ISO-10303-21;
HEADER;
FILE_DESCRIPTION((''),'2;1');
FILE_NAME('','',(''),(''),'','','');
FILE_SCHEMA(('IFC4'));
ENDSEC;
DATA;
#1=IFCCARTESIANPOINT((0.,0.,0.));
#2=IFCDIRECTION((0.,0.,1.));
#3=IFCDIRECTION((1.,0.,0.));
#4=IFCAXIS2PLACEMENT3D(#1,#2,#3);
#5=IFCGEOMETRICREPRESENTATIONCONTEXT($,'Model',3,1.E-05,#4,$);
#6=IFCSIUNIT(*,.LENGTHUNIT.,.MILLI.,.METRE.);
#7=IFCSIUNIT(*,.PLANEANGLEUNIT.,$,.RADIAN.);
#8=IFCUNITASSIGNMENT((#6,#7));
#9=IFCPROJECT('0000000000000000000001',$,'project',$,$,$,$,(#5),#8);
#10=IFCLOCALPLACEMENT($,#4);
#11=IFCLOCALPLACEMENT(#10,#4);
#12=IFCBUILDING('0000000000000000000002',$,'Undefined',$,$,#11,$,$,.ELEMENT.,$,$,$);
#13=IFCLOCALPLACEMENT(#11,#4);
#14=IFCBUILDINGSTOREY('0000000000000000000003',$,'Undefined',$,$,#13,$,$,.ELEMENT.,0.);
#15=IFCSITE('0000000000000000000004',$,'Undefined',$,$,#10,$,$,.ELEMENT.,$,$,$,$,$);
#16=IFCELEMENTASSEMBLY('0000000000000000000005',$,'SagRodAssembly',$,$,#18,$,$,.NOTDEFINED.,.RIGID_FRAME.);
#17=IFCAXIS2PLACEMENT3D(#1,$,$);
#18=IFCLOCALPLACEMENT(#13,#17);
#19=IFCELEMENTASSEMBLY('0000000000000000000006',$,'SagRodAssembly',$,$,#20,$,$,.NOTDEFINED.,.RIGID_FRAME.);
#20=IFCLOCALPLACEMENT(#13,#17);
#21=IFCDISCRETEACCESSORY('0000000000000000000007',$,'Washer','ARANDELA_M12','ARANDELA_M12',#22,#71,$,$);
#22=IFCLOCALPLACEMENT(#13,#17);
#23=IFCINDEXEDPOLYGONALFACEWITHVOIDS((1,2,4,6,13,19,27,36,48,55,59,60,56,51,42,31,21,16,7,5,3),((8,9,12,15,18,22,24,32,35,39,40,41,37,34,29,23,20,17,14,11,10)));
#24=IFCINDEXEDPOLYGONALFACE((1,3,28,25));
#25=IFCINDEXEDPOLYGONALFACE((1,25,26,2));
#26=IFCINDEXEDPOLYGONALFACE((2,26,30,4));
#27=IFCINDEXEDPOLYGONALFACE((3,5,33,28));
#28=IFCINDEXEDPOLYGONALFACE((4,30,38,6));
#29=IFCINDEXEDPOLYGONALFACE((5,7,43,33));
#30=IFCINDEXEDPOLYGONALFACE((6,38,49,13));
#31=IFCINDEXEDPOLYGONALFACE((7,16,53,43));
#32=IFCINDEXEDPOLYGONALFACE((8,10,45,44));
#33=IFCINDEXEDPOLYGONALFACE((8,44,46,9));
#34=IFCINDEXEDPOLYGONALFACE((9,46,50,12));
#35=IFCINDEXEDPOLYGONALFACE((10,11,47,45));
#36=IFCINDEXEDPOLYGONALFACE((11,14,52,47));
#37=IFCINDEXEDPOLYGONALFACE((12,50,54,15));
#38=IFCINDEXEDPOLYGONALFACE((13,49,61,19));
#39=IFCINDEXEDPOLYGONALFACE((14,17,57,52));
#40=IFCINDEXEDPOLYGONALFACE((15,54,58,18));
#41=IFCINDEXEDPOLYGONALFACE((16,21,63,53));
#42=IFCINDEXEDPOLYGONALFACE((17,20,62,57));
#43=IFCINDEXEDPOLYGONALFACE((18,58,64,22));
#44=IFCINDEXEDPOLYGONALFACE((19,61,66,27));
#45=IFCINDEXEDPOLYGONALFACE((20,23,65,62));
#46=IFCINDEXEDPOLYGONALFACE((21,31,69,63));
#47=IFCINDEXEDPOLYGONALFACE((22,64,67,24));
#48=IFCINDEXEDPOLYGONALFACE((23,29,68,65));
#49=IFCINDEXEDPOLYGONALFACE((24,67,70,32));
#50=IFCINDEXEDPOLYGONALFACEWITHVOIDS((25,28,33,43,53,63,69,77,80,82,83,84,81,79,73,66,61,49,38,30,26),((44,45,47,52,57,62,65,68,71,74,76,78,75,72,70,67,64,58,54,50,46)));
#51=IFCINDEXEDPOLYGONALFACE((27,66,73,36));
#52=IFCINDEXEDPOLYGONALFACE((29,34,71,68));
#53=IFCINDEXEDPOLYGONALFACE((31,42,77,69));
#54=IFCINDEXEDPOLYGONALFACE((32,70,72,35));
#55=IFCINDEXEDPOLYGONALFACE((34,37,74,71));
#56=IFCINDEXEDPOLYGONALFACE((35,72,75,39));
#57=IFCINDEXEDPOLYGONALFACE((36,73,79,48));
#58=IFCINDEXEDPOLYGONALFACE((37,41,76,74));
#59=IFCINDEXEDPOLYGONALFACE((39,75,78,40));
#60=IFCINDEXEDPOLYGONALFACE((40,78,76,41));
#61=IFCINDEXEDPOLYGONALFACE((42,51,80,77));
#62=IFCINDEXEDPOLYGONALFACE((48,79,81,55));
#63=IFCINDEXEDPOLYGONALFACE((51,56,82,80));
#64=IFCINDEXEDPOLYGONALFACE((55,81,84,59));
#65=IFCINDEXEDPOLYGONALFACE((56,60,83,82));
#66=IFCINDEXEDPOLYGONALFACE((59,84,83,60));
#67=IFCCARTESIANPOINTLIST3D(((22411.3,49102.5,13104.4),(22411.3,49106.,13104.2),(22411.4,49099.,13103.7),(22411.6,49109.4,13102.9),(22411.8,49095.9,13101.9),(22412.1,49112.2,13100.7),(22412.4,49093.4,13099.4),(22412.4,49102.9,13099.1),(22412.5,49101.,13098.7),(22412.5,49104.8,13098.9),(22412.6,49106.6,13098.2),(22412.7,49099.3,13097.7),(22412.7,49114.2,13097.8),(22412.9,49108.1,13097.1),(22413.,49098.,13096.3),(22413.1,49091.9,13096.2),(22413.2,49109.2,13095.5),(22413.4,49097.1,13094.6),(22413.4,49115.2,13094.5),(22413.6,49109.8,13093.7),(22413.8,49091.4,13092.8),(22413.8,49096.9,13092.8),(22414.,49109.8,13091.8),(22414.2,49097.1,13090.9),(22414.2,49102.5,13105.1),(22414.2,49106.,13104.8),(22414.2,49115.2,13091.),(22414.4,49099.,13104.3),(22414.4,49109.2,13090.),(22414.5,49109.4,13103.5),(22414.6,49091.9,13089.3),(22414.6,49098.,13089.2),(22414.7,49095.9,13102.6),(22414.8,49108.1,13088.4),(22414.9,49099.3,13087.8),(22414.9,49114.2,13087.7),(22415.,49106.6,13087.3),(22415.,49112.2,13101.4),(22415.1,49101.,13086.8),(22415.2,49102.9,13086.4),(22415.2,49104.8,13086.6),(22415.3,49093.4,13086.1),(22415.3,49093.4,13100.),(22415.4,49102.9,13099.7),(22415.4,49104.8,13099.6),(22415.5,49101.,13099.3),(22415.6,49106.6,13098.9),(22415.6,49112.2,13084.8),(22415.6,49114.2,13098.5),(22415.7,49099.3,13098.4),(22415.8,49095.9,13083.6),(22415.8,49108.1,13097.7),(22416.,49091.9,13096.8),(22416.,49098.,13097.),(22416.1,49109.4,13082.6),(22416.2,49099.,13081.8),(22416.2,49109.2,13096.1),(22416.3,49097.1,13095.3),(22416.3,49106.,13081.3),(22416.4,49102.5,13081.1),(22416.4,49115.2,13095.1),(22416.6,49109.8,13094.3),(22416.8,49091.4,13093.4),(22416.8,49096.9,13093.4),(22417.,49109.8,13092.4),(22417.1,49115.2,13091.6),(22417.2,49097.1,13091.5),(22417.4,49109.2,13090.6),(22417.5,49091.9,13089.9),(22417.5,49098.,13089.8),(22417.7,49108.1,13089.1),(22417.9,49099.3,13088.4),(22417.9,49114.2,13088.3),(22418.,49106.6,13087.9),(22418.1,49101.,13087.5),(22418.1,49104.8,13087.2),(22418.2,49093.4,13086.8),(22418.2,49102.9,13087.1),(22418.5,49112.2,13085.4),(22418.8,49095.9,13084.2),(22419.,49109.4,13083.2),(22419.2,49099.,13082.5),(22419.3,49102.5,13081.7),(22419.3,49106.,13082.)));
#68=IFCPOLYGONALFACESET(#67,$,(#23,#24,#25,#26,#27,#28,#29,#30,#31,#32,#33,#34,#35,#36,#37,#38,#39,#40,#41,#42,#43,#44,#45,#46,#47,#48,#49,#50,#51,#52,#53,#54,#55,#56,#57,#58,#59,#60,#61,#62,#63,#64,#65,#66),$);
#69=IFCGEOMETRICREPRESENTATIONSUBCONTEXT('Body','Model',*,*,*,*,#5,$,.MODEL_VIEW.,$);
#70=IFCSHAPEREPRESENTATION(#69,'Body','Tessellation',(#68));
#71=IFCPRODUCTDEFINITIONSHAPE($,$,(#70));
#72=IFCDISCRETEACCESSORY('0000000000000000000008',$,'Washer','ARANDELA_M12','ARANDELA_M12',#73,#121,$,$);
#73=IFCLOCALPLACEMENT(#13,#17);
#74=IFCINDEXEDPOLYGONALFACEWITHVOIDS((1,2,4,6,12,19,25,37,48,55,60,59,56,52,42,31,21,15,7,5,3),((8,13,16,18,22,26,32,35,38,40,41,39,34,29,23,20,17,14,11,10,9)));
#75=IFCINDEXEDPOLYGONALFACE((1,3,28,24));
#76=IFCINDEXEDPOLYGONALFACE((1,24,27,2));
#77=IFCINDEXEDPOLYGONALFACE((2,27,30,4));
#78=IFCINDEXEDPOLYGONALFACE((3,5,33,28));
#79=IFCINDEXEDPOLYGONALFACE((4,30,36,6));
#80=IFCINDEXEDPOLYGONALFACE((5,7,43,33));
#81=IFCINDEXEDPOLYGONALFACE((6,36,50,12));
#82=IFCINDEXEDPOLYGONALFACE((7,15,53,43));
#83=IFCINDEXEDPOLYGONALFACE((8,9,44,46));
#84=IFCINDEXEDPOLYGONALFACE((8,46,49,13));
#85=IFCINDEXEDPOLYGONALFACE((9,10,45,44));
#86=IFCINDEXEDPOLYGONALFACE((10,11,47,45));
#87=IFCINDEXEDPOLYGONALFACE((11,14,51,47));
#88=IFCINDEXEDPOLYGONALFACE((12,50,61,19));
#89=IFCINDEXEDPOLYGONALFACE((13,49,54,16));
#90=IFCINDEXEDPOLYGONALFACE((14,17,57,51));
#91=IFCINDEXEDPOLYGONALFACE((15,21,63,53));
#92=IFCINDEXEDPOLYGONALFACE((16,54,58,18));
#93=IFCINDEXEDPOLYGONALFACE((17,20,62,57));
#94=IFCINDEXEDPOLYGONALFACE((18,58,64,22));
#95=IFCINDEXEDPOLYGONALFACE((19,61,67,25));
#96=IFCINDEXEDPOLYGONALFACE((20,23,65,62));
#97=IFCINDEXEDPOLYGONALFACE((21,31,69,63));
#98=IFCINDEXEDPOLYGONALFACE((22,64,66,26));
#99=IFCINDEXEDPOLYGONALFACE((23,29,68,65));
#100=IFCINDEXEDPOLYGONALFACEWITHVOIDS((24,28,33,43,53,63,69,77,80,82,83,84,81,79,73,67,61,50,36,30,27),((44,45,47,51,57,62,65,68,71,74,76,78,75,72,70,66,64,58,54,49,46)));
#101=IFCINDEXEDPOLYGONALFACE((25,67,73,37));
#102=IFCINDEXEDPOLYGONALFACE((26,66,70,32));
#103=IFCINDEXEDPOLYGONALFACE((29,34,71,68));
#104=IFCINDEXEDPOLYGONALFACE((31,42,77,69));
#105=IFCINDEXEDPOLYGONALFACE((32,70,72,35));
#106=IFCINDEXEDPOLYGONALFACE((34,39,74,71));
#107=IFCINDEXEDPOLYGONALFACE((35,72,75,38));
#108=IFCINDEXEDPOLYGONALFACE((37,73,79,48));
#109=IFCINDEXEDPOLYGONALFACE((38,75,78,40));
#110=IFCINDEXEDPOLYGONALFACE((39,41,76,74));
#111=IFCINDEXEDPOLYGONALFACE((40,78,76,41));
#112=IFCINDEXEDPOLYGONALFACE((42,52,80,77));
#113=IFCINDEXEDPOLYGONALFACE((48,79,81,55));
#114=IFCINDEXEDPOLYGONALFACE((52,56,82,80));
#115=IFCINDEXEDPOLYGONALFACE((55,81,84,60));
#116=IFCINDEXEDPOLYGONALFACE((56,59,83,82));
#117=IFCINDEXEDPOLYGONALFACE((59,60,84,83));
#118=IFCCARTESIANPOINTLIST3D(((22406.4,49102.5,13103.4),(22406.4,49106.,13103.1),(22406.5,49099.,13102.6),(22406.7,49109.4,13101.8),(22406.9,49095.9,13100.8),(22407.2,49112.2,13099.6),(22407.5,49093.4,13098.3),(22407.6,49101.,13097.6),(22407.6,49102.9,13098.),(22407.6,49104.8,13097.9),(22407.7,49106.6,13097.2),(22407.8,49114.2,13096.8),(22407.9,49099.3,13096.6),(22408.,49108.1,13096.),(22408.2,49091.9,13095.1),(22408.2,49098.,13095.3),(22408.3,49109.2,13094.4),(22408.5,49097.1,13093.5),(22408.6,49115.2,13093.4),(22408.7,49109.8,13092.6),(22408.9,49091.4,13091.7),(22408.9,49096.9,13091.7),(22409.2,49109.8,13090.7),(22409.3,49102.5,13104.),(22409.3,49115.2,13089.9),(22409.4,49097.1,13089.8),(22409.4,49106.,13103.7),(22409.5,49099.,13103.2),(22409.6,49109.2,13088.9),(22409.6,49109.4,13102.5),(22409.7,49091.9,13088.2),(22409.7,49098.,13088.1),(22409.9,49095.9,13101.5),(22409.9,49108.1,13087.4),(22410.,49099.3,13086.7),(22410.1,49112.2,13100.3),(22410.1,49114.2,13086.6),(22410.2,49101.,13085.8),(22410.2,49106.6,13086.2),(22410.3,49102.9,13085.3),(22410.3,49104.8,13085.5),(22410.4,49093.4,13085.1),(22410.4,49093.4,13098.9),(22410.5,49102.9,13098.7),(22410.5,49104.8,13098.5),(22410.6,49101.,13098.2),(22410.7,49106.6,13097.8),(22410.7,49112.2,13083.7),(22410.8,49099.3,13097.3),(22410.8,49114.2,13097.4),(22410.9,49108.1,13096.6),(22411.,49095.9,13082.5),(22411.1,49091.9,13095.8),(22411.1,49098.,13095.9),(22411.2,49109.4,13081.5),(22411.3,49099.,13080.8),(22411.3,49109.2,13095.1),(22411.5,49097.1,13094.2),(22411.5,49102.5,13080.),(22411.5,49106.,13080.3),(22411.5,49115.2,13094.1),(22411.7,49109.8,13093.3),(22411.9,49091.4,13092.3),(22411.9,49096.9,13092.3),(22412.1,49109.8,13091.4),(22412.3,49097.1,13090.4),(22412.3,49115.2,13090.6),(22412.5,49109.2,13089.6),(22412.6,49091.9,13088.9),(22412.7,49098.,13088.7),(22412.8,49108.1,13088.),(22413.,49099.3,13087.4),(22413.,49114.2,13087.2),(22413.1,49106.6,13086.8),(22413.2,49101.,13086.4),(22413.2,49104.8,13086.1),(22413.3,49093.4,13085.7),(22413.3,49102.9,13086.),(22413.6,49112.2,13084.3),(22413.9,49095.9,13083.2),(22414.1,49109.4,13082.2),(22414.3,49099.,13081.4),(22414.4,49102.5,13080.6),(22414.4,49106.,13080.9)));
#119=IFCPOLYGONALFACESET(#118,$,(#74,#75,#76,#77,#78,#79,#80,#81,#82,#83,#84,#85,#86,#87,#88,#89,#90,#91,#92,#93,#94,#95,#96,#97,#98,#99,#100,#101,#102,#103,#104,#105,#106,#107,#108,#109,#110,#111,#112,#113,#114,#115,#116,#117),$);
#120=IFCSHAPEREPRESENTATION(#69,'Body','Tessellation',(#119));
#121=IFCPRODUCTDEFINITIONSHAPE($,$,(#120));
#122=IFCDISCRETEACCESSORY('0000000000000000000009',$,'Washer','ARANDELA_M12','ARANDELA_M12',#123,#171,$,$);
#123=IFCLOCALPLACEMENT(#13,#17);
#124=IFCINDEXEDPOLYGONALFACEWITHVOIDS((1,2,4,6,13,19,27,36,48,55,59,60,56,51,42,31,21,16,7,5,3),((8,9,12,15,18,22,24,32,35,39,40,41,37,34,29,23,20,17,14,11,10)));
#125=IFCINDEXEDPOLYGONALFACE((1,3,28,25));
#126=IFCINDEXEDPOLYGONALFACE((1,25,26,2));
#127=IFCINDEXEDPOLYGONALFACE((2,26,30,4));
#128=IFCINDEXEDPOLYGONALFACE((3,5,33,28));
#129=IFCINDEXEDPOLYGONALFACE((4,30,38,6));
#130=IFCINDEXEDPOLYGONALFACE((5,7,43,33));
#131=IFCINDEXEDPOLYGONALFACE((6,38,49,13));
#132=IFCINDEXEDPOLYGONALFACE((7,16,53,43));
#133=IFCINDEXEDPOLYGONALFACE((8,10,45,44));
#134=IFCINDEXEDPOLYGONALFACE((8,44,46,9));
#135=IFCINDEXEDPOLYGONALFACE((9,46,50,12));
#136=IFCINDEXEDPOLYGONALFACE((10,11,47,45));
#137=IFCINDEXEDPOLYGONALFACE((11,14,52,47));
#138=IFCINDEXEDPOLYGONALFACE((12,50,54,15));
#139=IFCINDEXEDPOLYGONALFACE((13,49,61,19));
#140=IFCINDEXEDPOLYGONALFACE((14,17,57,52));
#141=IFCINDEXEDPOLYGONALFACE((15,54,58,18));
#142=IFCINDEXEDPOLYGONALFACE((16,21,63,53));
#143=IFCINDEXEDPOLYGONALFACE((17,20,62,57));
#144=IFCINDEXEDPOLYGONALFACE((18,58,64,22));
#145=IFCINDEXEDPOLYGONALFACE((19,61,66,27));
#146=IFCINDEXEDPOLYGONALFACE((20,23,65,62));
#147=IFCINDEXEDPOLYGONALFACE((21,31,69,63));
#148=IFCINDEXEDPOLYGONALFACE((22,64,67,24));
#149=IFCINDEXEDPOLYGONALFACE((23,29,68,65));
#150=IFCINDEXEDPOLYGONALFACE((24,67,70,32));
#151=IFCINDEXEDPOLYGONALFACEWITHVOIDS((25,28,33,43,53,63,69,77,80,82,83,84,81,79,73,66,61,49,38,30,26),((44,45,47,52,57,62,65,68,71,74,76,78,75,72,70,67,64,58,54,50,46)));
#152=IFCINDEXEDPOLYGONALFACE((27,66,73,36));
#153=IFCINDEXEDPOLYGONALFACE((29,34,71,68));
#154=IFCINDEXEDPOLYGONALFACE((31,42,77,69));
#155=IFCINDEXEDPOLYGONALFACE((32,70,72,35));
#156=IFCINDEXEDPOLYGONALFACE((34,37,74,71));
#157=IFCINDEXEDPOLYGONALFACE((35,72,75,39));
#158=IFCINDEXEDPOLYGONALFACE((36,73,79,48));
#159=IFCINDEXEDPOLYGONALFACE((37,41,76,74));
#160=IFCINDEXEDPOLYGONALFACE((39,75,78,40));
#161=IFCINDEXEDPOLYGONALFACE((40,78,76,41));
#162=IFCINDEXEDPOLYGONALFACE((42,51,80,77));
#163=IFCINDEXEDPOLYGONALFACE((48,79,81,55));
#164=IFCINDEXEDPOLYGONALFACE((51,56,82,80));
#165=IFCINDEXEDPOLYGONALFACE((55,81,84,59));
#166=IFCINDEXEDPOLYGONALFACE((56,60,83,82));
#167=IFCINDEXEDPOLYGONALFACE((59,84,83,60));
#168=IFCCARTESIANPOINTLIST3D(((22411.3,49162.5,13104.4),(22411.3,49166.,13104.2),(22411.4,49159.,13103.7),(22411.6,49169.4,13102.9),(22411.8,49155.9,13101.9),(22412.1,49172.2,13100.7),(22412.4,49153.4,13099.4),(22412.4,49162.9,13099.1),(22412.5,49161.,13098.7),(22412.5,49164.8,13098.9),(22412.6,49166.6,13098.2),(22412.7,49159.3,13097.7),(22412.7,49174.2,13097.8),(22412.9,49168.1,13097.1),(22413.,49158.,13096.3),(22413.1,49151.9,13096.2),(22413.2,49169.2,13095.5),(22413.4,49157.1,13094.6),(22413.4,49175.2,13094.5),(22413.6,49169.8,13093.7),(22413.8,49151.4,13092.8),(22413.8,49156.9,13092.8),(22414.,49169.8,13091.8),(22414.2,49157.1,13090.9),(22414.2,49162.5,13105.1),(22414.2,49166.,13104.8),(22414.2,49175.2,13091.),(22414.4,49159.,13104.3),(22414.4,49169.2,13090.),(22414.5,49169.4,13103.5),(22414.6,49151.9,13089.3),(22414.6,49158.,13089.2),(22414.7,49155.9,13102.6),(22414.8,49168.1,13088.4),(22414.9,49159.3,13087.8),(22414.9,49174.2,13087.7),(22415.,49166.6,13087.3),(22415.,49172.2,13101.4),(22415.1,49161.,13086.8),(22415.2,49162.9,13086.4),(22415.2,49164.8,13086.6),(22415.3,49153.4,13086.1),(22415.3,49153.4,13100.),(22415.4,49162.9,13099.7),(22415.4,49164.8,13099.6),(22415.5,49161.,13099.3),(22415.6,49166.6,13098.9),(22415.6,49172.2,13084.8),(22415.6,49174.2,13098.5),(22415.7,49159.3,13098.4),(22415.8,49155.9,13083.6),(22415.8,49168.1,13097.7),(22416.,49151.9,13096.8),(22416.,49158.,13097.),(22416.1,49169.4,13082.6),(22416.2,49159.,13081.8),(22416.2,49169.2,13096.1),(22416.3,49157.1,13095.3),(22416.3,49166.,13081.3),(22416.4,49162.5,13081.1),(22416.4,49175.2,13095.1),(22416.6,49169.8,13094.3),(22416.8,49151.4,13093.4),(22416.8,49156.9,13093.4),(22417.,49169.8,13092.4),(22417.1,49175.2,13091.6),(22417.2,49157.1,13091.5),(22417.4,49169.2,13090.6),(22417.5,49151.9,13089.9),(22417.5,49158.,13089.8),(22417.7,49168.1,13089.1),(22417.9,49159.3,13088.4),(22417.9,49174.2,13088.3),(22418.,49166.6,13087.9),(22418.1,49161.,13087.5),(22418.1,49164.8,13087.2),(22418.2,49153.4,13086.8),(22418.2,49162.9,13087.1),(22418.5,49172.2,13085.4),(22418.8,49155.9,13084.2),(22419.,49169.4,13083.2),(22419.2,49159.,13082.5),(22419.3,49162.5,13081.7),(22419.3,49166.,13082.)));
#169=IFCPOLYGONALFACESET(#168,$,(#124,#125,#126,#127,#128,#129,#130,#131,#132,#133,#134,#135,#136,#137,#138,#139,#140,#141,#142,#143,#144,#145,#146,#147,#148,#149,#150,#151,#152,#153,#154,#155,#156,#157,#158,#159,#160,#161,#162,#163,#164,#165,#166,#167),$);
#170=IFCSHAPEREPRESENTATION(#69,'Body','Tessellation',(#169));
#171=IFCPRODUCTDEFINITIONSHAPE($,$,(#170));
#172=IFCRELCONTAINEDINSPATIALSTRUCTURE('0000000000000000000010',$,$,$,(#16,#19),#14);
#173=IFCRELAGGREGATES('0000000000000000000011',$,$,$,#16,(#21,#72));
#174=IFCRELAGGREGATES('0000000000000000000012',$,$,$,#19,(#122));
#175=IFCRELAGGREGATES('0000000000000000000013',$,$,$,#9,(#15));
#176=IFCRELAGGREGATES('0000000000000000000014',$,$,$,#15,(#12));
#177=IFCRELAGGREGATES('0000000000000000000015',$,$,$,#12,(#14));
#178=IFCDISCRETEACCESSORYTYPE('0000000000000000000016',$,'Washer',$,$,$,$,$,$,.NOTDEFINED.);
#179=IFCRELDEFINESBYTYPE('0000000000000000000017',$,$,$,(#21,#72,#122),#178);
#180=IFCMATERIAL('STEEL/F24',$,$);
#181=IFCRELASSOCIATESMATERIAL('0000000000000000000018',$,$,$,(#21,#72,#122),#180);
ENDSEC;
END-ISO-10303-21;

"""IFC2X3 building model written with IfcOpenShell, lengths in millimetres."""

from ifc_helpers import new_model, si_unit, frame, origin_with_axes, origin_2d_with_axis, place, context, subcontext, project, spatial, hollow_circle, extrude, material, type_object, element, aggregate, save


model = new_model("IFC2X3")

# Units and contexts
model_context = context("Model", 3, precision=1e-05, world=origin_with_axes())
body_context = subcontext(model_context, "Body", "Model", "MODEL_VIEW")
ifc_project = project(units=[si_unit("LENGTHUNIT", "METRE", prefix="MILLI"), si_unit("PLANEANGLEUNIT", "RADIAN")], contexts=[model_context])

# Site, building, storey
site_placement = place(None, origin_with_axes())
site = spatial("IfcSite", under=ifc_project, at=site_placement, Name="Undefined", CompositionType="ELEMENT")
building_placement = place(site_placement, origin_with_axes())
building = spatial("IfcBuilding", under=site, at=building_placement, Name="Undefined", CompositionType="ELEMENT")
storey_placement = place(building_placement, origin_with_axes())
storey = spatial("IfcBuildingStorey", under=building, at=storey_placement, Name="Undefined", CompositionType="ELEMENT", Elevation=0.0)

# Element assembly
ifc_material = material(Name="STEEL/F24")
assembly_1_placement = place(storey_placement, origin_with_axes())
assembly_1 = element("IfcElementAssembly", 1, at=assembly_1_placement, inside=storey, Name="SagRodAssembly", AssemblyPlace="NOTDEFINED", PredefinedType="RIGID_FRAME")

# Element assembly
assembly_2_placement = place(storey_placement, origin_with_axes())
assembly_2 = element("IfcElementAssembly", 2, at=assembly_2_placement, inside=storey, Name="SagRodAssembly", AssemblyPlace="NOTDEFINED", PredefinedType="RIGID_FRAME")

# Discrete accessories
discrete_accessory_type_1 = type_object("IfcDiscreteAccessoryType", Name="Washer")
discrete_accessory_1_placement = place(assembly_1_placement, frame((22413.8, 49103.4, 13092.8), z_axis=(-0.214887, 0.0, 0.976639), x_axis=(0.976639, 0.0, 0.214887)))
discrete_accessory_1 = element("IfcDiscreteAccessory", 3, at=discrete_accessory_1_placement, type_object=discrete_accessory_type_1, material=ifc_material, Name="Washer", Description="ARANDELA_M12", ObjectType="ARANDELA_M12", context=body_context, shape_type="SweptSolid", body=[
    extrude(hollow_circle(Radius=12.0, WallThickness=5.5, at=origin_2d_with_axis()), frame((3.0, 0.0, 0.0), z_axis=(-1.0, 0.0, 0.0), x_axis=(0.0, -1.0, 0.0)), (0.0, 0.0, 1.0), 3.0),
])
discrete_accessory_2_placement = place(assembly_1_placement, frame((22408.9, 49103.4, 13091.7), z_axis=(-0.214887, 0.0, 0.976639), x_axis=(0.976639, 0.0, 0.214887)))
discrete_accessory_2 = element("IfcDiscreteAccessory", 4, at=discrete_accessory_2_placement, type_object=discrete_accessory_type_1, material=ifc_material, Name="Washer", Description="ARANDELA_M12", ObjectType="ARANDELA_M12", context=body_context, shape_type="SweptSolid", body=[
    extrude(hollow_circle(Radius=12.0, WallThickness=5.5, at=origin_2d_with_axis()), frame((3.0, 0.0, 0.0), z_axis=(-1.0, 0.0, 0.0), x_axis=(0.0, -1.0, 0.0)), (0.0, 0.0, 1.0), 3.0),
])
aggregate(assembly_1, [discrete_accessory_1, discrete_accessory_2])
discrete_accessory_3_placement = place(assembly_2_placement, frame((22413.8, 49163.4, 13092.8), z_axis=(-0.214887, 0.0, 0.976639), x_axis=(0.976639, 0.0, 0.214887)))
discrete_accessory_3 = element("IfcDiscreteAccessory", 5, at=discrete_accessory_3_placement, type_object=discrete_accessory_type_1, material=ifc_material, Name="Washer", Description="ARANDELA_M12", ObjectType="ARANDELA_M12", context=body_context, shape_type="SweptSolid", body=[
    extrude(hollow_circle(Radius=12.0, WallThickness=5.5, at=origin_2d_with_axis()), frame((3.0, 0.0, 0.0), z_axis=(-1.0, 0.0, 0.0), x_axis=(0.0, -1.0, 0.0)), (0.0, 0.0, 1.0), 3.0),
])
aggregate(assembly_2, [discrete_accessory_3])

save(model, "model.ifc")
